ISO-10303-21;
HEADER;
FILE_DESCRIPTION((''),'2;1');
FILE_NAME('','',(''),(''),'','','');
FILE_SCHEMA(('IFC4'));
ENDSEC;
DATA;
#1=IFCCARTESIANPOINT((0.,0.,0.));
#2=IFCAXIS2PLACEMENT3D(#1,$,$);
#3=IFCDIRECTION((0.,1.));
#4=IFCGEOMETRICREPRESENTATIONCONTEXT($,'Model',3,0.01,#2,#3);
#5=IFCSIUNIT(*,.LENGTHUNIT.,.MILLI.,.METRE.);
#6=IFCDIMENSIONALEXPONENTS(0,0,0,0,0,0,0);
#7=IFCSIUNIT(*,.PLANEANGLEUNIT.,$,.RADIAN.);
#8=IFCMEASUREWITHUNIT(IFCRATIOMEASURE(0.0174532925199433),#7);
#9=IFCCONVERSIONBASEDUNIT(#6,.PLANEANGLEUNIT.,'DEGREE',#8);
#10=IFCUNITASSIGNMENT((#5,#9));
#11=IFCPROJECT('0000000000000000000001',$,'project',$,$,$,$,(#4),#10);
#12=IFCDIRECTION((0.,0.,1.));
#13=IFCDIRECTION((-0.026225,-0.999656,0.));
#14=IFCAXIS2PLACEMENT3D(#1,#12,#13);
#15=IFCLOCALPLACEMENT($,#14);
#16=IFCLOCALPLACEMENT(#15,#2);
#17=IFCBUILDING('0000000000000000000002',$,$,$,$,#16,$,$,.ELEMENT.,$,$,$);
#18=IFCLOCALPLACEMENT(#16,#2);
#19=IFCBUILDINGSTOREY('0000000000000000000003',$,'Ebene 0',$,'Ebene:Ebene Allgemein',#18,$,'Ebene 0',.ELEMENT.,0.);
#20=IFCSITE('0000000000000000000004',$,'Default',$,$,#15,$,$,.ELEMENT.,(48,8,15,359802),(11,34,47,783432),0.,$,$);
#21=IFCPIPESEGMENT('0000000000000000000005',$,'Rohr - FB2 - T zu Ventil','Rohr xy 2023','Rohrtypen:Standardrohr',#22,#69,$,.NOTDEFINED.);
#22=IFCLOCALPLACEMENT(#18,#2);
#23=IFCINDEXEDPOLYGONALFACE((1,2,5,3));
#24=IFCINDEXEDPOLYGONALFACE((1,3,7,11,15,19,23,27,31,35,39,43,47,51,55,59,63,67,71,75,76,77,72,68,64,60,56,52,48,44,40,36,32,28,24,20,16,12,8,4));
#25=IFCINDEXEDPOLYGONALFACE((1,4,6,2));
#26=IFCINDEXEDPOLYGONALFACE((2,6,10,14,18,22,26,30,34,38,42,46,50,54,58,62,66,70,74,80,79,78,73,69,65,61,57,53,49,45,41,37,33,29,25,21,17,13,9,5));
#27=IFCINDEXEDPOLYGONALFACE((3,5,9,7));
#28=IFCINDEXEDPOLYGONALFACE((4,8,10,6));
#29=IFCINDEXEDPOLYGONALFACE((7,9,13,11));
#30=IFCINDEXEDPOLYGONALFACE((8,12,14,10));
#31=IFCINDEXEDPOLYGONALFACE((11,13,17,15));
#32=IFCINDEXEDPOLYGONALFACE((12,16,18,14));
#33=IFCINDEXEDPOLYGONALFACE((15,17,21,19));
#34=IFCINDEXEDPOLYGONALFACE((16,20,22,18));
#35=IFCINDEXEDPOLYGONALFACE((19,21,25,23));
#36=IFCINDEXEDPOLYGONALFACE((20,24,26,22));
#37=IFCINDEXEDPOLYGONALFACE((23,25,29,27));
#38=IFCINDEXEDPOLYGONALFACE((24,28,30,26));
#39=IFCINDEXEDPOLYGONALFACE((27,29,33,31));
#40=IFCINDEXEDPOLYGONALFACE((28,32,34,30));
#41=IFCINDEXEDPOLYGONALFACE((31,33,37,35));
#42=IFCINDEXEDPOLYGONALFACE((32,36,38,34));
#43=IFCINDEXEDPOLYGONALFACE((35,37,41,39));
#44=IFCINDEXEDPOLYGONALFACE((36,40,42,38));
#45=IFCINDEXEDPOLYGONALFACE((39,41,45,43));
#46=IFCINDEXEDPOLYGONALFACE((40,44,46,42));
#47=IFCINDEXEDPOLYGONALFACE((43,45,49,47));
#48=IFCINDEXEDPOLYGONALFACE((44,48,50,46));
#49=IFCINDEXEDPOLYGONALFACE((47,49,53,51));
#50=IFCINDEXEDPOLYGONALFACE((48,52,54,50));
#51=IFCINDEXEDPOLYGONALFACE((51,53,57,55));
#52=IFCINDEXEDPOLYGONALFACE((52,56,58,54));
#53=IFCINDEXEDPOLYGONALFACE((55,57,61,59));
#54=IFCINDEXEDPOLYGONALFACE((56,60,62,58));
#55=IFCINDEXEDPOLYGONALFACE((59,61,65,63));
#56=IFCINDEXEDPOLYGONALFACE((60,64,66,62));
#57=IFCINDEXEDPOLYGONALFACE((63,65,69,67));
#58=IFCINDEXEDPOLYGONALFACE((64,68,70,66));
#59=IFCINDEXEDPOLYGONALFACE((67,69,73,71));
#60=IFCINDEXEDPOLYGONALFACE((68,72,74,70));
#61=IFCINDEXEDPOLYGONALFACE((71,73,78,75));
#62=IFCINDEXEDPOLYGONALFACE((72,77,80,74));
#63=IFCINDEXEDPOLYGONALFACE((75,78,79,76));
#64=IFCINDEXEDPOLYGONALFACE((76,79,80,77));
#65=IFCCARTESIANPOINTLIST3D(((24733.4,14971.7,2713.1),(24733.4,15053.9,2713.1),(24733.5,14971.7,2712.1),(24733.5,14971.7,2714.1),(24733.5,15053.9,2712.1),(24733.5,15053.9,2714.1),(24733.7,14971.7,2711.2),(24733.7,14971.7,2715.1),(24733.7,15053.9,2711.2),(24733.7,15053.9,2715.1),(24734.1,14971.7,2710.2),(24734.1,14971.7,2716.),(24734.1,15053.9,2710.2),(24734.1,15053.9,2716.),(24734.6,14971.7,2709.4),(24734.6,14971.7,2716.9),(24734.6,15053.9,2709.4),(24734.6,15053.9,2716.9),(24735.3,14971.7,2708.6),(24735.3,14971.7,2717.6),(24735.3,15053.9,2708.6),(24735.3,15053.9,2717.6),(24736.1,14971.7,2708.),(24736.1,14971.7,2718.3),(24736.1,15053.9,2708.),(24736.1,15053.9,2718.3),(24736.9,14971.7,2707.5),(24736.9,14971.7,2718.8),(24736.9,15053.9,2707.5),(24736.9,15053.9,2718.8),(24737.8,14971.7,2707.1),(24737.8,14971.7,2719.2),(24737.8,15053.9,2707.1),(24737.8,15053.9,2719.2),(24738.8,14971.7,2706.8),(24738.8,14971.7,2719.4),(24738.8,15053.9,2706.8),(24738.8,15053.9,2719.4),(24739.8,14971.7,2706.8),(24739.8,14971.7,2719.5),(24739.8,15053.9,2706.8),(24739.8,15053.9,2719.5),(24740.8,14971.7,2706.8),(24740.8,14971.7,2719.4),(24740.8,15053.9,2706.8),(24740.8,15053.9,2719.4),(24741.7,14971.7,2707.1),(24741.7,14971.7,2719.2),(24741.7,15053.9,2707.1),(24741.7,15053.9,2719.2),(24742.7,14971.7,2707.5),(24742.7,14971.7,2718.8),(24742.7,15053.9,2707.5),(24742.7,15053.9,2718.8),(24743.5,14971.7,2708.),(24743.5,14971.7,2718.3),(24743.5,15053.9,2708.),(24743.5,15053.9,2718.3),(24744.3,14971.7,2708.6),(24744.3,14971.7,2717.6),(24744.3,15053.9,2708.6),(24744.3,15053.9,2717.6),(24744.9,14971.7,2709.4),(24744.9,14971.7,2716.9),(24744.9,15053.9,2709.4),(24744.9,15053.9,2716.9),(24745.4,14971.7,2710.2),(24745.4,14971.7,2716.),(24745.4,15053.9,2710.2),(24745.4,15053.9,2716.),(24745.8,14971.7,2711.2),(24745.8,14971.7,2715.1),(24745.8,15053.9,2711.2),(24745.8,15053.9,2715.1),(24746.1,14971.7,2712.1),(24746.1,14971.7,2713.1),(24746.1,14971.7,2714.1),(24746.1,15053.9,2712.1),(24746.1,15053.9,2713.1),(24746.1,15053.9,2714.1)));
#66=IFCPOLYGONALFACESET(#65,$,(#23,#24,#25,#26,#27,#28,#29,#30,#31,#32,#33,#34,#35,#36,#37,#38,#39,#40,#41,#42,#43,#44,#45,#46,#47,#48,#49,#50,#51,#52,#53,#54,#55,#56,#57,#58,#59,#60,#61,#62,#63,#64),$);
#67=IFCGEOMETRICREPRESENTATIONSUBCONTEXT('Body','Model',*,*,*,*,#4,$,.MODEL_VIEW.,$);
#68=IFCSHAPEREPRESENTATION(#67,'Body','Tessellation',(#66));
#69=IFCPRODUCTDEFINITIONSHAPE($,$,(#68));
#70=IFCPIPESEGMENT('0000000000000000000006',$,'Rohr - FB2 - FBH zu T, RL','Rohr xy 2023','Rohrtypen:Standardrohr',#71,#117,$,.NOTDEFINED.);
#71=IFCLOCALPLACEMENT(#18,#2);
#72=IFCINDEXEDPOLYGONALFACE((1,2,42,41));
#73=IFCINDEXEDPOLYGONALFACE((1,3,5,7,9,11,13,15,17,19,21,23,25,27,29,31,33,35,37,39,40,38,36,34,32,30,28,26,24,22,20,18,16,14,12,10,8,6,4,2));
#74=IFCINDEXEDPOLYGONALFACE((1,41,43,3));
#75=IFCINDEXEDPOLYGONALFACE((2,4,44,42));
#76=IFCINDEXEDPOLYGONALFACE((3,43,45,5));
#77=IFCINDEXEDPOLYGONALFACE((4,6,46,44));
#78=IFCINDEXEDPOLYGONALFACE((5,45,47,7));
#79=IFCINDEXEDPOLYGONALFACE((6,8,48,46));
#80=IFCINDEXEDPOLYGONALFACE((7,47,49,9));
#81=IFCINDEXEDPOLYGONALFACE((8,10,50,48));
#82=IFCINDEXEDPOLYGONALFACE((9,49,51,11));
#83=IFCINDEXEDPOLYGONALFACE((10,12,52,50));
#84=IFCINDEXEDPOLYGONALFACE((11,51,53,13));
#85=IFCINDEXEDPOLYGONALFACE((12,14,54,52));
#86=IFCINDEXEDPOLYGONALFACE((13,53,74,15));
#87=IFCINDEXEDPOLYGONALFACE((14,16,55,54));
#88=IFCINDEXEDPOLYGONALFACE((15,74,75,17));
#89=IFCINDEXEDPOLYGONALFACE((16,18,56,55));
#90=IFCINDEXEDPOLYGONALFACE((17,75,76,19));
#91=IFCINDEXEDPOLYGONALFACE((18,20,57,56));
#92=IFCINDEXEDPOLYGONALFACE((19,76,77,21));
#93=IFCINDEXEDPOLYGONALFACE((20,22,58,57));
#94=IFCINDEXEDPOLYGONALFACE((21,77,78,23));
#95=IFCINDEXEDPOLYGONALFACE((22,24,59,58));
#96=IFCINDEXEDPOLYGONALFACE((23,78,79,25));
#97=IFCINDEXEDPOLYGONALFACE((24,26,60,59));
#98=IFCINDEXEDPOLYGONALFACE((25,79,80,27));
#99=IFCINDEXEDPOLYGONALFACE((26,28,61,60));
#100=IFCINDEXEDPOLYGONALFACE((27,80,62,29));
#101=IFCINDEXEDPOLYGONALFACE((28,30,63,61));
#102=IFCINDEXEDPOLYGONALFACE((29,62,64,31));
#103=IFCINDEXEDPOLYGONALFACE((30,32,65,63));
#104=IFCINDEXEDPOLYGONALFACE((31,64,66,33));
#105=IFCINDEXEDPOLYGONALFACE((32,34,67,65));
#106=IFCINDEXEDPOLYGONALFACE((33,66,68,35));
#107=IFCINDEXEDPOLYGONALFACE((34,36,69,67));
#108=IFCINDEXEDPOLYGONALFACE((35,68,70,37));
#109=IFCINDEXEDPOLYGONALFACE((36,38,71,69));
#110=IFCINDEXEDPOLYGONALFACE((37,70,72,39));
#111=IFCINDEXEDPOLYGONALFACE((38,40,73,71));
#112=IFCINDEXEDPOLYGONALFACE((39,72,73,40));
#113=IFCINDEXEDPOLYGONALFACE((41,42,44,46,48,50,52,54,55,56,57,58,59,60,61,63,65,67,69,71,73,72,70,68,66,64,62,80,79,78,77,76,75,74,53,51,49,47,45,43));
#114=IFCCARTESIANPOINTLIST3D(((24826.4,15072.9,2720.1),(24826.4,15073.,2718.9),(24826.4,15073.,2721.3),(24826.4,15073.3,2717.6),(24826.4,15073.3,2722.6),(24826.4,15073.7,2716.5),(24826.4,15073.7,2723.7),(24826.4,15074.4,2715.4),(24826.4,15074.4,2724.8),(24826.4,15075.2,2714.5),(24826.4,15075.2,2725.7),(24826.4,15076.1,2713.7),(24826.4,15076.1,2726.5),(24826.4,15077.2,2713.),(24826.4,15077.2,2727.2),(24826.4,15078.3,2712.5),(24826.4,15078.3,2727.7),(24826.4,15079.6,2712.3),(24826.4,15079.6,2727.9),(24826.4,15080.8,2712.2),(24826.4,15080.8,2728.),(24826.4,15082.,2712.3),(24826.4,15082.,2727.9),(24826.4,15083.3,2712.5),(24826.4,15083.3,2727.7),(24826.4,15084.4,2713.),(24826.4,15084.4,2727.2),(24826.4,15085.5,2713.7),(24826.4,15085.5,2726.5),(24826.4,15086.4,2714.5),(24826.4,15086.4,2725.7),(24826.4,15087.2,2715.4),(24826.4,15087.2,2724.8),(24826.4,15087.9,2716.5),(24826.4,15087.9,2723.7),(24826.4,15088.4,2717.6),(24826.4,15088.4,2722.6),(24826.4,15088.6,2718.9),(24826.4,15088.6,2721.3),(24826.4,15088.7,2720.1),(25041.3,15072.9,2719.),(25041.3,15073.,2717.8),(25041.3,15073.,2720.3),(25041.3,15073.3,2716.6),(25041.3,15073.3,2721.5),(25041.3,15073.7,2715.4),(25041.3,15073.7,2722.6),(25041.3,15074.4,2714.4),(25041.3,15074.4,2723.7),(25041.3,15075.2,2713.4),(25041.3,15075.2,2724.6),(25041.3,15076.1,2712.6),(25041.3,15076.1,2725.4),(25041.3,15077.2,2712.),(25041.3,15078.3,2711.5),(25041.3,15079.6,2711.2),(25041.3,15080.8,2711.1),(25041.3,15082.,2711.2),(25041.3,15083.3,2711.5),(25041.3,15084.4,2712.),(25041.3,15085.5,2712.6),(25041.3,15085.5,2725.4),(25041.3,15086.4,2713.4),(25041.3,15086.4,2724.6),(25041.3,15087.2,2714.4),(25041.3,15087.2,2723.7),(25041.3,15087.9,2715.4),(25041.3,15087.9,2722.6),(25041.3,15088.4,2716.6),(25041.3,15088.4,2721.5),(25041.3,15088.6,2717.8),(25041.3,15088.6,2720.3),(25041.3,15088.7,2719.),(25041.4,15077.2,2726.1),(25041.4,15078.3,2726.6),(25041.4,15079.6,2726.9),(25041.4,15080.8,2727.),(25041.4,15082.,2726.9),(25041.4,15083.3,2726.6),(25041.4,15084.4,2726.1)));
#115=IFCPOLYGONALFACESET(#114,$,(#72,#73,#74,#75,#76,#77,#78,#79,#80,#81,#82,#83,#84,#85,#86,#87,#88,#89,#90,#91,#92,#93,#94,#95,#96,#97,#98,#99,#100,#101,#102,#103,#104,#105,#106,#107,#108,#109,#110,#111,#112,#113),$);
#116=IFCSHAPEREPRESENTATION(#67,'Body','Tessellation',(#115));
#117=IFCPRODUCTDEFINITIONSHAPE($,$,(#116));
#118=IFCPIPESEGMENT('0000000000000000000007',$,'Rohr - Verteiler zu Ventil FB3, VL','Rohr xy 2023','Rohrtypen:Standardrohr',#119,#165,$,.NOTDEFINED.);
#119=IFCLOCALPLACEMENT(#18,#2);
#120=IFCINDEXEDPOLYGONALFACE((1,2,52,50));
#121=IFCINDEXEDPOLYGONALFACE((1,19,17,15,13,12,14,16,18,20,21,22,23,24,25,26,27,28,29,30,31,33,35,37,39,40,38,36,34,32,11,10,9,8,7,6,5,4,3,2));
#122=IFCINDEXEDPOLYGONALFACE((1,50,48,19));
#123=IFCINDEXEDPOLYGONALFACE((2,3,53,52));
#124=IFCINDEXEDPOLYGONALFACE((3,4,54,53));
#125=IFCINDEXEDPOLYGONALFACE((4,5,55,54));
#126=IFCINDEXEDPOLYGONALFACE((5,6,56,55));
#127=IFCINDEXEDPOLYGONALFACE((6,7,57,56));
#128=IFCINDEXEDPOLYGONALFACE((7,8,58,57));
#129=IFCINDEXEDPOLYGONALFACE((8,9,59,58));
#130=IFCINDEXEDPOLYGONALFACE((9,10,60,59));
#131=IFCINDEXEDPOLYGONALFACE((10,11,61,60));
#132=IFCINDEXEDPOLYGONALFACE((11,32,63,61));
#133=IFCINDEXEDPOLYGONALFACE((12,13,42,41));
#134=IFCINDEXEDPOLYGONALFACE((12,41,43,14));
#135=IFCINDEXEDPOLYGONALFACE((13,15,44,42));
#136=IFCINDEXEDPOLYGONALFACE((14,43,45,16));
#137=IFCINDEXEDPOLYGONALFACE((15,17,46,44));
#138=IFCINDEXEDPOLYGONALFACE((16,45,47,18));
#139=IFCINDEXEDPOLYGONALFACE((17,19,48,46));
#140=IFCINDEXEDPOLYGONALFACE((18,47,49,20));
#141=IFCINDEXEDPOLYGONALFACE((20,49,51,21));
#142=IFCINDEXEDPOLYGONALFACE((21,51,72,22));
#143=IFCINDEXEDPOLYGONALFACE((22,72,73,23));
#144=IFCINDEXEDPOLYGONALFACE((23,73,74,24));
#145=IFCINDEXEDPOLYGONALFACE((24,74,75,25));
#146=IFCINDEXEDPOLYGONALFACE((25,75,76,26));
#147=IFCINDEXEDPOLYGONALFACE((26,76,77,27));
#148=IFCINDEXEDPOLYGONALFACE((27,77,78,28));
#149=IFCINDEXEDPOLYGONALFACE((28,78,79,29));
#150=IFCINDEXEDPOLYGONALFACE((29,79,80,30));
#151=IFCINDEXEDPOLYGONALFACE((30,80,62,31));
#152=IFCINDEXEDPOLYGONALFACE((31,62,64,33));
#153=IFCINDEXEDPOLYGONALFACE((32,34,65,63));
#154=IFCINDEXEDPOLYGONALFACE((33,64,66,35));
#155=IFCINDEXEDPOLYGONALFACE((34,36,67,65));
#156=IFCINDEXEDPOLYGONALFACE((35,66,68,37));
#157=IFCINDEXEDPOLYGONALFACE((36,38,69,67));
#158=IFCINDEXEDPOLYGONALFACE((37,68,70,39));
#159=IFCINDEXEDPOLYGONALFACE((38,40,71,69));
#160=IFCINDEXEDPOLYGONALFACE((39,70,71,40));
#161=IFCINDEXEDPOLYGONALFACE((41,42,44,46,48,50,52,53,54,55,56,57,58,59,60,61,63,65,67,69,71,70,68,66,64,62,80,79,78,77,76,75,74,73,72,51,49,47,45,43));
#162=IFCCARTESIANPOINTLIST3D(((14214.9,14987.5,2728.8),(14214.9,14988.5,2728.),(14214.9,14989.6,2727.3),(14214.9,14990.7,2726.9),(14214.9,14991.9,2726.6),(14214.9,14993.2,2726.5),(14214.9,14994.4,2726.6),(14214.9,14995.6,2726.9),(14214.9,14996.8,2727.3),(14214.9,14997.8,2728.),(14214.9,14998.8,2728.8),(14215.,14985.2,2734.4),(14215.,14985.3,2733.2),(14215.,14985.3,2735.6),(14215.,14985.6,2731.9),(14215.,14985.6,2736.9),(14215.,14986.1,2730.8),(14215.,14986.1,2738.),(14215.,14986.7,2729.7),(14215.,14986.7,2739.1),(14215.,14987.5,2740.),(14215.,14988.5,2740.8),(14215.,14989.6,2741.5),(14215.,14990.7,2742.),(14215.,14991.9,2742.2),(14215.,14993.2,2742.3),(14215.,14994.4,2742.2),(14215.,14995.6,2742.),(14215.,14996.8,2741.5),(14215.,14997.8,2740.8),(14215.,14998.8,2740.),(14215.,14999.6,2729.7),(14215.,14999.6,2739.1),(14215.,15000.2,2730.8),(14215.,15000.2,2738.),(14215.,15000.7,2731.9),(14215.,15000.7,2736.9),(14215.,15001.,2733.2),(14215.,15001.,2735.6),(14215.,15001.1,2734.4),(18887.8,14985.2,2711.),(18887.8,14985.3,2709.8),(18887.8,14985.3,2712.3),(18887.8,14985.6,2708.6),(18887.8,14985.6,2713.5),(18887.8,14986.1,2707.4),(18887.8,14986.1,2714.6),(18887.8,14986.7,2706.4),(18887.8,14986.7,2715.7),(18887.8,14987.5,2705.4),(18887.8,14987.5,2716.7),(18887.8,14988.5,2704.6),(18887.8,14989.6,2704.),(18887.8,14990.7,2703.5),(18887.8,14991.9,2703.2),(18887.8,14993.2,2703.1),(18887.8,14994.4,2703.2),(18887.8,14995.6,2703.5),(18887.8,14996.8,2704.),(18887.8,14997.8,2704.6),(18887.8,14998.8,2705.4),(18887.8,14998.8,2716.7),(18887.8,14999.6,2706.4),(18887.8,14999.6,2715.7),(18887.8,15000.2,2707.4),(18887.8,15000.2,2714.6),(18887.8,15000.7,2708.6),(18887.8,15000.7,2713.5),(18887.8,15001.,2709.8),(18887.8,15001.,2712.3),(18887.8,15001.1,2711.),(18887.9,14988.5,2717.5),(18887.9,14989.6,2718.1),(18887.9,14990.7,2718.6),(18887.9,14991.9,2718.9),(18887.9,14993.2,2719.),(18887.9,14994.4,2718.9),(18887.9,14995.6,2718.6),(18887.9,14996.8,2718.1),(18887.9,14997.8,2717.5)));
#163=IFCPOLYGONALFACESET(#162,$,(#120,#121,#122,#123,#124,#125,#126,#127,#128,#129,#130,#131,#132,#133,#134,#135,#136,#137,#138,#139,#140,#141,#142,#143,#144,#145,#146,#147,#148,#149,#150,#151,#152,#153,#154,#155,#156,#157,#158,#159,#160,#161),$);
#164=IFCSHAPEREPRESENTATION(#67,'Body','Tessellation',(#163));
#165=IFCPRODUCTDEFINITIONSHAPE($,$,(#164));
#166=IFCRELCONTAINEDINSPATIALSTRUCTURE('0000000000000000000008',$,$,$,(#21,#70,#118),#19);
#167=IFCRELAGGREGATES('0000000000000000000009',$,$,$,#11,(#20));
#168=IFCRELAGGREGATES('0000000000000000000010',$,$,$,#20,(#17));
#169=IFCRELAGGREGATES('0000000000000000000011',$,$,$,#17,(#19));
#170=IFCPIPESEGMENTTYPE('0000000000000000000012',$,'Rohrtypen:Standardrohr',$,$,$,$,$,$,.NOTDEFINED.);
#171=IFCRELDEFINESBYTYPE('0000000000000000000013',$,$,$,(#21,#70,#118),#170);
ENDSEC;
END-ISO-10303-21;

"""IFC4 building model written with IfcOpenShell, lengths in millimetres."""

from ifc_helpers import new_model, entity, si_unit, converted_unit, direction, frame, origin, place, context, subcontext, project, spatial, indexed_curve, outline, extrude, type_object, element, save


model = new_model("IFC4")

# Units and contexts
model_context = context("Model", 3, precision=0.01, world=origin(), true_north=direction((0.0, 1.0)))
body_context = subcontext(model_context, "Body", "Model", "MODEL_VIEW")
ifc_project = project(units=[si_unit("LENGTHUNIT", "METRE", prefix="MILLI"), converted_unit("PLANEANGLEUNIT", "DEGREE", entity("IfcRatioMeasure", 0.0174532925199433), si_unit("PLANEANGLEUNIT", "RADIAN"), dimensions=[0, 0, 0, 0, 0, 0, 0])], contexts=[model_context])

# Site, building, storey
site_placement = place(None, frame((0.0, 0.0, 0.0), z_axis=(0.0, 0.0, 1.0), x_axis=(-0.026225, -0.999656, 0.0)))
site = spatial("IfcSite", under=ifc_project, at=site_placement, Name="Default", CompositionType="ELEMENT", RefLatitude=(48, 8, 15, 359802), RefLongitude=(11, 34, 47, 783432), RefElevation=0.0)
building_placement = place(site_placement, origin())
building = spatial("IfcBuilding", under=site, at=building_placement, CompositionType="ELEMENT")
storey_placement = place(building_placement, origin())
storey = spatial("IfcBuildingStorey", under=building, at=storey_placement, Name="Ebene 0", ObjectType="Ebene:Ebene Allgemein", LongName="Ebene 0", CompositionType="ELEMENT", Elevation=0.0)

# Pipe segments
pipe_segment_type = type_object("IfcPipeSegmentType", Name="Rohrtypen:Standardrohr", PredefinedType="NOTDEFINED")
pipe_segment_1_placement = place(storey_placement, origin())
element("IfcPipeSegment", 1, at=pipe_segment_1_placement, inside=storey, type_object=pipe_segment_type, Name="Rohr - FB2 - T zu Ventil", Description="Rohr xy 2023", ObjectType="Rohrtypen:Standardrohr", PredefinedType="NOTDEFINED", context=body_context, shape_type="SweptSolid", body=[
    extrude(outline(indexed_curve([(6.3, 0.0), (6.3, 1.0), (6.0, 2.0), (5.7, 2.9), (5.1, 3.7), (4.5, 4.5), (3.7, 5.1), (2.9, 5.7), (2.0, 6.0), (1.0, 6.3), (0.0, 6.4), (-1.0, 6.3), (-2.0, 6.0), (-2.9, 5.7), (-3.7, 5.1), (-4.5, 4.5), (-5.1, 3.7), (-5.7, 2.9), (-6.0, 2.0), (-6.3, 1.0), (-6.3, 0.0), (-6.3, -1.0), (-6.0, -2.0), (-5.7, -2.9), (-5.1, -3.7), (-4.5, -4.5), (-3.7, -5.1), (-2.9, -5.7), (-2.0, -6.0), (-1.0, -6.3), (0.0, -6.4), (1.0, -6.3), (2.0, -6.0), (2.9, -5.7), (3.7, -5.1), (4.5, -4.5), (5.1, -3.7), (5.7, -2.9), (6.0, -2.0), (6.3, -1.0), (6.3, 0.0)], self_intersect=False)), frame((24739.8, 14971.7, 2713.1), z_axis=(0.0, 1.0, 0.0), x_axis=(-1.0, 0.0, 0.0)), (0.0, 0.0, 1.0), 82.2),
])
pipe_segment_2_placement = place(storey_placement, origin())
element("IfcPipeSegment", 2, at=pipe_segment_2_placement, inside=storey, type_object=pipe_segment_type, Name="Rohr - FB2 - FBH zu T, RL", Description="Rohr xy 2023", ObjectType="Rohrtypen:Standardrohr", PredefinedType="NOTDEFINED", context=body_context, shape_type="SweptSolid", body=[
    extrude(outline(indexed_curve([(7.9, 0.0), (7.8, 1.2), (7.6, 2.5), (7.1, 3.6), (6.4, 4.7), (5.6, 5.6), (4.7, 6.4), (3.6, 7.1), (2.5, 7.6), (1.2, 7.8), (0.0, 7.9), (-1.2, 7.8), (-2.5, 7.6), (-3.6, 7.1), (-4.7, 6.4), (-5.6, 5.6), (-6.4, 4.7), (-7.1, 3.6), (-7.6, 2.5), (-7.8, 1.2), (-7.9, 0.0), (-7.8, -1.2), (-7.6, -2.5), (-7.1, -3.6), (-6.4, -4.7), (-5.6, -5.6), (-4.7, -6.4), (-3.6, -7.1), (-2.5, -7.6), (-1.2, -7.8), (0.0, -7.9), (1.2, -7.8), (2.5, -7.6), (3.6, -7.1), (4.7, -6.4), (5.6, -5.6), (6.4, -4.7), (7.1, -3.6), (7.6, -2.5), (7.8, -1.2), (7.9, 0.0)], self_intersect=False)), frame((25041.3, 15080.8, 2719.0), z_axis=(-0.999988, 0.0, 0.005), x_axis=(0.0, 1.0, 0.0)), (0.0, 0.0, 1.0), 214.9),
])
pipe_segment_3_placement = place(storey_placement, origin())
element("IfcPipeSegment", 3, at=pipe_segment_3_placement, inside=storey, type_object=pipe_segment_type, Name="Rohr - Verteiler zu Ventil FB3, VL", Description="Rohr xy 2023", ObjectType="Rohrtypen:Standardrohr", PredefinedType="NOTDEFINED", context=body_context, shape_type="SweptSolid", body=[
    extrude(outline(indexed_curve([(7.9, 0.0), (7.8, 1.2), (7.6, 2.5), (7.1, 3.6), (6.4, 4.7), (5.6, 5.6), (4.7, 6.4), (3.6, 7.1), (2.5, 7.6), (1.2, 7.8), (0.0, 7.9), (-1.2, 7.8), (-2.5, 7.6), (-3.6, 7.1), (-4.7, 6.4), (-5.6, 5.6), (-6.4, 4.7), (-7.1, 3.6), (-7.6, 2.5), (-7.8, 1.2), (-7.9, 0.0), (-7.8, -1.2), (-7.6, -2.5), (-7.1, -3.6), (-6.4, -4.7), (-5.6, -5.6), (-4.7, -6.4), (-3.6, -7.1), (-2.5, -7.6), (-1.2, -7.8), (0.0, -7.9), (1.2, -7.8), (2.5, -7.6), (3.6, -7.1), (4.7, -6.4), (5.6, -5.6), (6.4, -4.7), (7.1, -3.6), (7.6, -2.5), (7.8, -1.2), (7.9, 0.0)], self_intersect=False)), frame((18887.8, 14993.2, 2711.0), z_axis=(-0.999988, 0.0, 0.005), x_axis=(0.0, 1.0, 0.0)), (0.0, 0.0, 1.0), 4672.9),
])

save(model, "model.ifc")
